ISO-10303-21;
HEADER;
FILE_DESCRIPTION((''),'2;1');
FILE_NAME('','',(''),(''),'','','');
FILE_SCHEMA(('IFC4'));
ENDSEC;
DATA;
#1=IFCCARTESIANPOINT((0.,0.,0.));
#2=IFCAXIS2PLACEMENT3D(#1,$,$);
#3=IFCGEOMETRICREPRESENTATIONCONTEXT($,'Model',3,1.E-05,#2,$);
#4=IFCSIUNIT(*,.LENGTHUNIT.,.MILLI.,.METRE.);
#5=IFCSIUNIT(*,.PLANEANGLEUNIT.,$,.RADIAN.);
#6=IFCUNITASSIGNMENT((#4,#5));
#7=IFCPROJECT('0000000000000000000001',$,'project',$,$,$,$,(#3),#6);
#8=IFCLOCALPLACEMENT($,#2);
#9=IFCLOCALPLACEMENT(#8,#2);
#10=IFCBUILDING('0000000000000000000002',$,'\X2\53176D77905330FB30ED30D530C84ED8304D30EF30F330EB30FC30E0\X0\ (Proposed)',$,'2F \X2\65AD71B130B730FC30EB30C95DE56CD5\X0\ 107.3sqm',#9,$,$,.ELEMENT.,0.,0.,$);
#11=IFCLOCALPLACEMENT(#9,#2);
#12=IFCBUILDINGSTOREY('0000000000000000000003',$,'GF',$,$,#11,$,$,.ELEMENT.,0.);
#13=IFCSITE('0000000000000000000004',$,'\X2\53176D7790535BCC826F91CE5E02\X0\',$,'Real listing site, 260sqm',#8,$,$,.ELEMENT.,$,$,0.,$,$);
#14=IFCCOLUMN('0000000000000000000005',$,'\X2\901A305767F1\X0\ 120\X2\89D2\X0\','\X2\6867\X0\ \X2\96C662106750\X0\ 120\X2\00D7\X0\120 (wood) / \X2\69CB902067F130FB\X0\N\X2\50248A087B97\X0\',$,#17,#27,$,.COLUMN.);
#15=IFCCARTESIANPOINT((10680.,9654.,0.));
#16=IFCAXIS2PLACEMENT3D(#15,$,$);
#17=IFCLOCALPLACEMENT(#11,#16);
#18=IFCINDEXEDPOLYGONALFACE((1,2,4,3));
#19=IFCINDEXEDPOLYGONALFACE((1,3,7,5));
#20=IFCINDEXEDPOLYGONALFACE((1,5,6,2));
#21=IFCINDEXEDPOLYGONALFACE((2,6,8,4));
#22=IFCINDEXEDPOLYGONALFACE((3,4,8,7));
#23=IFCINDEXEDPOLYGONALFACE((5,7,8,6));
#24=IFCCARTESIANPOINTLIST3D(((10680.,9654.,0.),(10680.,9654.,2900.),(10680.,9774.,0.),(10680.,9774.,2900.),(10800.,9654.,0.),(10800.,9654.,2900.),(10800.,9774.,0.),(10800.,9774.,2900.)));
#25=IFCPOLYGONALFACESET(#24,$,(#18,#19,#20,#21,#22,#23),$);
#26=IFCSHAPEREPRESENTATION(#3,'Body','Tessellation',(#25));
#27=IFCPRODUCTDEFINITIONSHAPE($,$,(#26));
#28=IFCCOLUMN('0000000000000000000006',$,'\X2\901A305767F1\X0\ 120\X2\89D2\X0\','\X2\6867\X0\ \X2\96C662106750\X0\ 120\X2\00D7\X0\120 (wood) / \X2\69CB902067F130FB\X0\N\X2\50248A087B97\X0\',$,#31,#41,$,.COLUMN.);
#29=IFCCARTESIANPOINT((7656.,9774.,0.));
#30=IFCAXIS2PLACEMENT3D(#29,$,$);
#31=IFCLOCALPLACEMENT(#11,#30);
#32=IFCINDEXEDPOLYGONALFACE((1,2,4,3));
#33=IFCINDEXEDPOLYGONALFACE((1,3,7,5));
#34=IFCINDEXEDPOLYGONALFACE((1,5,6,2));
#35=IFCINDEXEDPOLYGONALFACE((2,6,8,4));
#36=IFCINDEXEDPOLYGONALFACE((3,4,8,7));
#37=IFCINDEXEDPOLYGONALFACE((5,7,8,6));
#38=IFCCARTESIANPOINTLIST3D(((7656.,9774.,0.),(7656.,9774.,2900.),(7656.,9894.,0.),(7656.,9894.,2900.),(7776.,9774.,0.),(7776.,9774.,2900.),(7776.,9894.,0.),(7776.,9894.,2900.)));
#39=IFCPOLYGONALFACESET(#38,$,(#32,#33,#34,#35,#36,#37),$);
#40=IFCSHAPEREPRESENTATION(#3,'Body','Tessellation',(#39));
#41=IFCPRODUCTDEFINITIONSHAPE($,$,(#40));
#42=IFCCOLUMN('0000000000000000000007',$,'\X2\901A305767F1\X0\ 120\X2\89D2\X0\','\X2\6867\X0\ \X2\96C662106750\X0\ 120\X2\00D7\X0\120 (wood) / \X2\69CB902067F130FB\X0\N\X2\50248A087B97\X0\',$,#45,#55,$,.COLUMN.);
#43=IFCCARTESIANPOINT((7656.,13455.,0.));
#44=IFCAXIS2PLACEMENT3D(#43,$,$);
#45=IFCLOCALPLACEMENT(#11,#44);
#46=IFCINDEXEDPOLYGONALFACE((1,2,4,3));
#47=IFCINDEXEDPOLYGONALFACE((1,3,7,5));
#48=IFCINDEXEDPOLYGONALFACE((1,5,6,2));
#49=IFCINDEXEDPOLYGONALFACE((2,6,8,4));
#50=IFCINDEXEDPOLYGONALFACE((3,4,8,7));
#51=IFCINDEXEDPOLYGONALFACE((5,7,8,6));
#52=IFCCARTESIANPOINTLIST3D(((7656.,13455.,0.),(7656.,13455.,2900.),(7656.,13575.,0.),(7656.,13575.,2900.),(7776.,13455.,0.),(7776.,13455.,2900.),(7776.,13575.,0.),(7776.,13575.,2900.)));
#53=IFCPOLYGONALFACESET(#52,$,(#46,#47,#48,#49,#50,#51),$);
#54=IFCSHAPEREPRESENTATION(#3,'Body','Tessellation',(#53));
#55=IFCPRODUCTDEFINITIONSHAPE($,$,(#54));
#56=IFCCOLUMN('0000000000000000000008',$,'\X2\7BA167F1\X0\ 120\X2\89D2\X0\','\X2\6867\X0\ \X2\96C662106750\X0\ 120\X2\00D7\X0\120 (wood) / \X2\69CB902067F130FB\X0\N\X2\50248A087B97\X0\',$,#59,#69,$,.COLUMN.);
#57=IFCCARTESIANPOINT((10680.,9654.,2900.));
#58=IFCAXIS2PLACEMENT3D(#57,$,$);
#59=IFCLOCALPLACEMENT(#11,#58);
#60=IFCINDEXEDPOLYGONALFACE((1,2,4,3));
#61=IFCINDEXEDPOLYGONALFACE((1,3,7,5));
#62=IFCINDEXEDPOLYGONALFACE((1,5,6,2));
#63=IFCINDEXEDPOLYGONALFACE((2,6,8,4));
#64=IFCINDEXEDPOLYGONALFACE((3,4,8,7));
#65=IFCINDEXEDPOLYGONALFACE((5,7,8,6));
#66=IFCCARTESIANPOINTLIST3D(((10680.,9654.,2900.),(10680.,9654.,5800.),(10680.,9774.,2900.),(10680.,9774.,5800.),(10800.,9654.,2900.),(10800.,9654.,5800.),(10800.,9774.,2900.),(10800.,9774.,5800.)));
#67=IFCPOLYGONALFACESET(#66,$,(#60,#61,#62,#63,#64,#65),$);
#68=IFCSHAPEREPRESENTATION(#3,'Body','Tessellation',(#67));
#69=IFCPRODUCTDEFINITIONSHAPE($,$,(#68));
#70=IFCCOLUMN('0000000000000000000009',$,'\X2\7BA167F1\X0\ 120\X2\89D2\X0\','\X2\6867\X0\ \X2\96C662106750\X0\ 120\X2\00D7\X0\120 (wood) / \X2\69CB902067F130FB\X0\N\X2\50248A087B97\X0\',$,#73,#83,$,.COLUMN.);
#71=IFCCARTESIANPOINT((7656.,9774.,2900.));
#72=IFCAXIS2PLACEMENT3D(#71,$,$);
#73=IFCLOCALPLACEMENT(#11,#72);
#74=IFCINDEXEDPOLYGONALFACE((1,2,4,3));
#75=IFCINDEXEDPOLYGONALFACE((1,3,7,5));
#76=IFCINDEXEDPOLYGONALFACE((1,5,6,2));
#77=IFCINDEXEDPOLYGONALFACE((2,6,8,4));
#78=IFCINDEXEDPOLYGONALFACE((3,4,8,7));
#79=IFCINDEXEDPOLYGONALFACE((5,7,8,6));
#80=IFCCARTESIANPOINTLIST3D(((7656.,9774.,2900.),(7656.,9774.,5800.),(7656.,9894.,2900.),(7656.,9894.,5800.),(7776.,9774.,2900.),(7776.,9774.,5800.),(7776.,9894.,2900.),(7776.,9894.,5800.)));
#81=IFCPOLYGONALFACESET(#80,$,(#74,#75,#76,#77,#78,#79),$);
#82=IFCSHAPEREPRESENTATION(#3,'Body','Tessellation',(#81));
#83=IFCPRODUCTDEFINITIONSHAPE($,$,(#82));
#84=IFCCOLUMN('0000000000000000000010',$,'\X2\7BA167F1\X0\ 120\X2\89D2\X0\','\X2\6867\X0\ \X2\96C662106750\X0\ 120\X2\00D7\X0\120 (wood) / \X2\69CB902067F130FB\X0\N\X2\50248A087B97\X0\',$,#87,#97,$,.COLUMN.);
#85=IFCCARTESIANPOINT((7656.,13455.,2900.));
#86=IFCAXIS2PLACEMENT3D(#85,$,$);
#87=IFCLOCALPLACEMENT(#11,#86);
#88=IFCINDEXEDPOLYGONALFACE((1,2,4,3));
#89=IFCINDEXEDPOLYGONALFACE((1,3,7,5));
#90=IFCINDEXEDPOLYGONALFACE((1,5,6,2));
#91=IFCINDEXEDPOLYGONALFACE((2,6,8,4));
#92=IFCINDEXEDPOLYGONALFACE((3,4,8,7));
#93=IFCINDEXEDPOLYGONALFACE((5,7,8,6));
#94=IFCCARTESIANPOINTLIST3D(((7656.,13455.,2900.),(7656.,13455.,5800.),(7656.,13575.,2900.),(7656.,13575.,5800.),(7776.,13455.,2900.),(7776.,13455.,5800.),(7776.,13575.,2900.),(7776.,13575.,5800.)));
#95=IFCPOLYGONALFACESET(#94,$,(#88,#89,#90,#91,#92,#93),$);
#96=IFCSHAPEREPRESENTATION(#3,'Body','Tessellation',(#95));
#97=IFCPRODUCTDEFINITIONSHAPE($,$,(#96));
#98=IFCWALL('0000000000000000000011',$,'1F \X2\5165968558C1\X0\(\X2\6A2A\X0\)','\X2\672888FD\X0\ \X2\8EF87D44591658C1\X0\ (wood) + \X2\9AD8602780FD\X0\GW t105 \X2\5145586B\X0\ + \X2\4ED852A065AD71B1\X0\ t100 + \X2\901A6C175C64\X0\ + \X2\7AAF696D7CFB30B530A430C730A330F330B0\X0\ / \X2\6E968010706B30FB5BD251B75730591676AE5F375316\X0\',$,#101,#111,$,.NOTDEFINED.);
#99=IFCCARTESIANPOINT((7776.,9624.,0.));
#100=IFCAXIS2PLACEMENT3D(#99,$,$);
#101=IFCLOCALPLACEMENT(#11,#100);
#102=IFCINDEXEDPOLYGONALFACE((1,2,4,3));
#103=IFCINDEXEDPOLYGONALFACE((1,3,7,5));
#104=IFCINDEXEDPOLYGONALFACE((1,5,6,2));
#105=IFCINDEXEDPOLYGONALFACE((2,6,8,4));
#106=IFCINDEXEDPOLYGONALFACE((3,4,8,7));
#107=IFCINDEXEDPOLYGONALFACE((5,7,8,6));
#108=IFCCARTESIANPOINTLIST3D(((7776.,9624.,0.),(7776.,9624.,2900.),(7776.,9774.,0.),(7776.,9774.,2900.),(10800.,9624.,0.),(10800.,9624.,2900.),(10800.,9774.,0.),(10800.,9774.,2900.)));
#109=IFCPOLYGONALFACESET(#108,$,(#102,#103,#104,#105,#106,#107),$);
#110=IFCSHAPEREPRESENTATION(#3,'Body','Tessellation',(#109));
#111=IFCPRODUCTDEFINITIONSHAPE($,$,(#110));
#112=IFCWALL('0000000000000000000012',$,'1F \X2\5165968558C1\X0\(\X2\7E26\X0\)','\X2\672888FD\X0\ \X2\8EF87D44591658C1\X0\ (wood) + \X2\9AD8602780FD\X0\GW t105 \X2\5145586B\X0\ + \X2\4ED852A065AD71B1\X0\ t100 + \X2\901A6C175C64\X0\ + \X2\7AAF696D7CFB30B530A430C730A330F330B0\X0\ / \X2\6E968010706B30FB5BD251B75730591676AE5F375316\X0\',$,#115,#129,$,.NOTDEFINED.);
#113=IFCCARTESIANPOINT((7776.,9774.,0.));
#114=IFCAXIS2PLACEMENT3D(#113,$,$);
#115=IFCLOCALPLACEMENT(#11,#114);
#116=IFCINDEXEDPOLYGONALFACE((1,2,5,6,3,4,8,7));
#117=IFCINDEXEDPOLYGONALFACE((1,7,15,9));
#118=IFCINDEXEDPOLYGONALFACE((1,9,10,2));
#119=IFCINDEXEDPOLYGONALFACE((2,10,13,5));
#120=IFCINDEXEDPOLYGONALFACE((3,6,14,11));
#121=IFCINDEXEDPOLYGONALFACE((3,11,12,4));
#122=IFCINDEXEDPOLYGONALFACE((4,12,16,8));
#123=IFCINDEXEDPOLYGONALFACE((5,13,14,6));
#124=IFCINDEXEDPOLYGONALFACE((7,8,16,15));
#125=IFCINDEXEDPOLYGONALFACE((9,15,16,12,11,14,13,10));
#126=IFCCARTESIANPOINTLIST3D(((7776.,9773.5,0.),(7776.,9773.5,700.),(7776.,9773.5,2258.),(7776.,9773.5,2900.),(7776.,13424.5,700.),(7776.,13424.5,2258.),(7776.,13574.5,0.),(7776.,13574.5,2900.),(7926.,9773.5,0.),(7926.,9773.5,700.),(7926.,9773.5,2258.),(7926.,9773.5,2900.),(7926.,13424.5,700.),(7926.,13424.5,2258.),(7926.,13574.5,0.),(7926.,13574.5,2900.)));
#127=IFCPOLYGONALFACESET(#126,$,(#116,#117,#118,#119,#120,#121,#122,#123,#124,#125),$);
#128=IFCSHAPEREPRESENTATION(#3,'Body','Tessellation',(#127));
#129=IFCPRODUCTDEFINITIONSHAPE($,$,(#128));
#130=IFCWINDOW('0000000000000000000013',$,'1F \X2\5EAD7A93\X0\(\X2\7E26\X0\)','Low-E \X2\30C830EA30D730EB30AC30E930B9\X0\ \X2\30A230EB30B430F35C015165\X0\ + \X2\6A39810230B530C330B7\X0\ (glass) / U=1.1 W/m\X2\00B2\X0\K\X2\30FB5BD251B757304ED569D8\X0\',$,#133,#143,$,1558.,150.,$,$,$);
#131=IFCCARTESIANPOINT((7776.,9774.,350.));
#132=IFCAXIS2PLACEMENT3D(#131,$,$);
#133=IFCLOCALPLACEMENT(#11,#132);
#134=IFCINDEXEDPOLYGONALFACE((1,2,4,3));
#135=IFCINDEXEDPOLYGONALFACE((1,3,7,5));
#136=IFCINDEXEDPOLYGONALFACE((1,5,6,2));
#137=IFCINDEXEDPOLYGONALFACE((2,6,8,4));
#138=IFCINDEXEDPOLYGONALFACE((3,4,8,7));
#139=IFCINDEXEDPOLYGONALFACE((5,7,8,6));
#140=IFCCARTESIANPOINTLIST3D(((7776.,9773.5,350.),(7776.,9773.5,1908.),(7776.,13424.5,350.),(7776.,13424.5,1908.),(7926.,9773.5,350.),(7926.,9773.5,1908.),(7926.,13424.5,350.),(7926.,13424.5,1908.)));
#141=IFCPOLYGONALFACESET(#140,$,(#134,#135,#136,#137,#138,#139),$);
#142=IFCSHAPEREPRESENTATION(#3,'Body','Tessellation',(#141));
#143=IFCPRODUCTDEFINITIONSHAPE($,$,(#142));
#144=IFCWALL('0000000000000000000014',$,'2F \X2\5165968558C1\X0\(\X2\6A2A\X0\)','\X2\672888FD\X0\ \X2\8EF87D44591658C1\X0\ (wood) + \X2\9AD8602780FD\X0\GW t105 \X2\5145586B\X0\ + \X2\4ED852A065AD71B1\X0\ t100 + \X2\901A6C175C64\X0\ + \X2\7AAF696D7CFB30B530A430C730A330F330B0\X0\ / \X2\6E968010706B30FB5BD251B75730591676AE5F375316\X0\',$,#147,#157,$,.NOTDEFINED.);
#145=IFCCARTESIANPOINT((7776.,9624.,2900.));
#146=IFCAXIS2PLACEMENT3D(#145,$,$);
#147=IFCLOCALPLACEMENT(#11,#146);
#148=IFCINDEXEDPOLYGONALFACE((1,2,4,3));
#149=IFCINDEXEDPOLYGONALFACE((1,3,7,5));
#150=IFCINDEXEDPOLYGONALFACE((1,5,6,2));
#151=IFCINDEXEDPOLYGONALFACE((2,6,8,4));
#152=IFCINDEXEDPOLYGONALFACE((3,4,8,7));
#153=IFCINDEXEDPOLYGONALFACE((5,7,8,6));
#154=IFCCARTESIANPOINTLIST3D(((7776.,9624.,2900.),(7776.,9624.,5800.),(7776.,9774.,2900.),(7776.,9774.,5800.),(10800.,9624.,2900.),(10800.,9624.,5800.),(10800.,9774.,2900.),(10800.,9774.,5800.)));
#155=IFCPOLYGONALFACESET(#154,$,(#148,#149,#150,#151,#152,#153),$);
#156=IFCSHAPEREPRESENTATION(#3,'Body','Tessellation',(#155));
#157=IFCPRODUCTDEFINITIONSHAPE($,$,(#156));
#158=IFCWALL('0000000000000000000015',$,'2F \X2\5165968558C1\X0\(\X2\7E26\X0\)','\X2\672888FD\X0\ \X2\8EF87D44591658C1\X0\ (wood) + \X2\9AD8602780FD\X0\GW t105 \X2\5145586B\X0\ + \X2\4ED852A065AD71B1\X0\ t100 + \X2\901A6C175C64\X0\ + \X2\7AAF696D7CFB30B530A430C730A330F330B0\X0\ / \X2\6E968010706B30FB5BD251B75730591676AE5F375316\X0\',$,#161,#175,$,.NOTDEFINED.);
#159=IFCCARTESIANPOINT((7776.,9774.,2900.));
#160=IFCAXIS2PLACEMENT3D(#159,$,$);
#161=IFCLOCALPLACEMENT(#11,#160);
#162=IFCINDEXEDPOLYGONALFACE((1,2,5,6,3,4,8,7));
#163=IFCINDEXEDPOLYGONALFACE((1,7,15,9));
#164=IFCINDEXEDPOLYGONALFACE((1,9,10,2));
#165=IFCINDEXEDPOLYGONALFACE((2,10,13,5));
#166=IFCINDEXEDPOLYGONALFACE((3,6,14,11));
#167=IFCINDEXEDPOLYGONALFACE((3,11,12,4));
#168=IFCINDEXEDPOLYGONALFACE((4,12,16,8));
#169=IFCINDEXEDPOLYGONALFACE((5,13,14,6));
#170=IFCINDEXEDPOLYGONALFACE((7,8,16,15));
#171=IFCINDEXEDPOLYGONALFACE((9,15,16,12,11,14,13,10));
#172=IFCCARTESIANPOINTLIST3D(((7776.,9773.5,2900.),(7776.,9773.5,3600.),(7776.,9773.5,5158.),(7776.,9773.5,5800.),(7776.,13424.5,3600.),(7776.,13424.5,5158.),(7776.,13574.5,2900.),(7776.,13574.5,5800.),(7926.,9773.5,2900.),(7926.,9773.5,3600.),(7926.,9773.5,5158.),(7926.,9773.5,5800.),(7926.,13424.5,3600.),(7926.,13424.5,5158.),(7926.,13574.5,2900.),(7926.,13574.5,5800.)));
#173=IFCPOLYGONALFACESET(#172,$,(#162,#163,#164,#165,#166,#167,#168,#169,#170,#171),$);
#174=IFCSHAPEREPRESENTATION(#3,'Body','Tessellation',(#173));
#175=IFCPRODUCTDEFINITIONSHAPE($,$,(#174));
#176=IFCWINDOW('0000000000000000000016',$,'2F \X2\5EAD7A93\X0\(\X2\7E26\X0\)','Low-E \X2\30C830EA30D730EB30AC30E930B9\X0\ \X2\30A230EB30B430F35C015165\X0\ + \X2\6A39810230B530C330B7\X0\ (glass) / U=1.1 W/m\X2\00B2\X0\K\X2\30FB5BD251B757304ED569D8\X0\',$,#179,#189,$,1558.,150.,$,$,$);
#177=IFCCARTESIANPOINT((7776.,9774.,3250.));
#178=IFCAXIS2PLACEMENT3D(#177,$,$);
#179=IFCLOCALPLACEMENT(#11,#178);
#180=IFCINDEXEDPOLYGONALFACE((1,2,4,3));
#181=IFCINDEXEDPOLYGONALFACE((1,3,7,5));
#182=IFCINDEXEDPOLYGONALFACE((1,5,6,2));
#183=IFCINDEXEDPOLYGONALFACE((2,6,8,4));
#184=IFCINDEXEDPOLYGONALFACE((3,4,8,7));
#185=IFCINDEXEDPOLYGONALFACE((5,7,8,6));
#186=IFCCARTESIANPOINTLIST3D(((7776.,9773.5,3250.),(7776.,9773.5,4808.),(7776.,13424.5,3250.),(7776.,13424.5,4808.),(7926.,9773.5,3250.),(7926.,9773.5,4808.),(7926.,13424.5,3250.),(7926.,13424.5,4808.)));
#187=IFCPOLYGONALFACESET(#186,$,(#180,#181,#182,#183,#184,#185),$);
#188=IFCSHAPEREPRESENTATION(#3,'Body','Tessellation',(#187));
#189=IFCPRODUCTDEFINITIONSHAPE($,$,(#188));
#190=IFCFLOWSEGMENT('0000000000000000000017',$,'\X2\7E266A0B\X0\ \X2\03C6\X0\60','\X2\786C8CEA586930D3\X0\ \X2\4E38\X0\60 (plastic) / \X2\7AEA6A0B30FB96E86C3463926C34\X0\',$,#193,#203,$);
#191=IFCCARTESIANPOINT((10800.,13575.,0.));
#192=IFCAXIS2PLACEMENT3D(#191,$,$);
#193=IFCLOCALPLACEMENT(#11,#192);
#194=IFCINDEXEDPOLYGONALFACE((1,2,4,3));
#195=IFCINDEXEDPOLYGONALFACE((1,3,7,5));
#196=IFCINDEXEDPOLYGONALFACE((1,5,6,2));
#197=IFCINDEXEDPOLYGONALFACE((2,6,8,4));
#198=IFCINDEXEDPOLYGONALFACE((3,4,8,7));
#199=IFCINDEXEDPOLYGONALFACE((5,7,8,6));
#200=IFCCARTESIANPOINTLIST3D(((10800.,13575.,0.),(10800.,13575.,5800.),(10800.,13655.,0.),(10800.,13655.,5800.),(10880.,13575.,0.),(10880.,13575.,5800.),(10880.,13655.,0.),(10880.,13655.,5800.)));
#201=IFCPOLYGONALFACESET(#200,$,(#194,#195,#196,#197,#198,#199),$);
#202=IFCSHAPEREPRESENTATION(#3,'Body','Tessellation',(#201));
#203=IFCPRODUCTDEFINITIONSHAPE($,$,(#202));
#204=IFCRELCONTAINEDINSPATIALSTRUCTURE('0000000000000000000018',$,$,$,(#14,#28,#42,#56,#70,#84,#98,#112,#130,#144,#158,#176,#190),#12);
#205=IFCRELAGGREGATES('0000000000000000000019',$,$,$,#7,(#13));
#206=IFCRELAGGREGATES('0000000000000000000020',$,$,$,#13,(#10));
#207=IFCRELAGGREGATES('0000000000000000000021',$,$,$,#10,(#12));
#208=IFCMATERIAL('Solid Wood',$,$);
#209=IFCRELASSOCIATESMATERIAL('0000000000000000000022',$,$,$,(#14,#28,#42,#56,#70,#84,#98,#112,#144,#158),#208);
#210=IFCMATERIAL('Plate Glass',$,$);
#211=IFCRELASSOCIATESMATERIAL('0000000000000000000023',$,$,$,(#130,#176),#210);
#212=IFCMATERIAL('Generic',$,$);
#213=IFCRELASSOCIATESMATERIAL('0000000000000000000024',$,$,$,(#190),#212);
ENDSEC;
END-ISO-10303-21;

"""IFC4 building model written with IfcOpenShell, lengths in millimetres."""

from ifc_helpers import new_model, si_unit, frame, frame_2d, origin, place, context, project, spatial, rectangle, extrude, material, element, fill, save


model = new_model("IFC4")

# Units and contexts
model_context = context("Model", 3, precision=1e-05, world=origin())
ifc_project = project(units=[si_unit("LENGTHUNIT", "METRE", prefix="MILLI"), si_unit("PLANEANGLEUNIT", "RADIAN")], contexts=[model_context])

# Site, building, storey
site_placement = place(None, origin())
site = spatial("IfcSite", under=ifc_project, at=site_placement, Name="北海道富良野市", ObjectType="Real listing site, 260sqm", CompositionType="ELEMENT", RefElevation=0.0)
building_placement = place(site_placement, origin())
building = spatial("IfcBuilding", under=site, at=building_placement, Name="北海道・ロフト付きワンルーム (Proposed)", ObjectType="2F 断熱シールド工法 107.3sqm", CompositionType="ELEMENT", ElevationOfRefHeight=0.0, ElevationOfTerrain=0.0)
storey_placement = place(building_placement, origin())
storey = spatial("IfcBuildingStorey", under=building, at=storey_placement, Name="GF", CompositionType="ELEMENT", Elevation=0.0)

# Columns
ifc_material_1 = material(Name="Solid Wood")
column_1_placement = place(storey_placement, frame((10680.0, 9654.0, 0.0)))
element("IfcColumn", 1, at=column_1_placement, inside=storey, material=ifc_material_1, Name="通し柱 120角", Description="桧 集成材 120×120 (wood) / 構造柱・N値計算", PredefinedType="COLUMN", context=model_context, shape_type="SweptSolid", body=[
    extrude(rectangle(XDim=120.0, YDim=120.0, at=frame_2d((60.0, 60.0))), frame((10680.0, 9654.0, 0.0)), (0.0, 0.0, 1.0), 2900.0),
])
column_2_placement = place(storey_placement, frame((7656.0, 9774.0, 0.0)))
element("IfcColumn", 2, at=column_2_placement, inside=storey, material=ifc_material_1, Name="通し柱 120角", Description="桧 集成材 120×120 (wood) / 構造柱・N値計算", PredefinedType="COLUMN", context=model_context, shape_type="SweptSolid", body=[
    extrude(rectangle(XDim=120.0, YDim=120.0, at=frame_2d((60.0, 60.0))), frame((7656.0, 9774.0, 0.0)), (0.0, 0.0, 1.0), 2900.0),
])
column_3_placement = place(storey_placement, frame((7656.0, 13455.0, 0.0)))
element("IfcColumn", 3, at=column_3_placement, inside=storey, material=ifc_material_1, Name="通し柱 120角", Description="桧 集成材 120×120 (wood) / 構造柱・N値計算", PredefinedType="COLUMN", context=model_context, shape_type="SweptSolid", body=[
    extrude(rectangle(XDim=120.0, YDim=120.0, at=frame_2d((60.0, 60.0))), frame((7656.0, 13455.0, 0.0)), (0.0, 0.0, 1.0), 2900.0),
])
column_4_placement = place(storey_placement, frame((10680.0, 9654.0, 2900.0)))
element("IfcColumn", 4, at=column_4_placement, inside=storey, material=ifc_material_1, Name="管柱 120角", Description="桧 集成材 120×120 (wood) / 構造柱・N値計算", PredefinedType="COLUMN", context=model_context, shape_type="SweptSolid", body=[
    extrude(rectangle(XDim=120.0, YDim=120.0, at=frame_2d((60.0, 60.0))), frame((10680.0, 9654.0, 2900.0)), (0.0, 0.0, 1.0), 2900.0),
])
column_5_placement = place(storey_placement, frame((7656.0, 9774.0, 2900.0)))
element("IfcColumn", 5, at=column_5_placement, inside=storey, material=ifc_material_1, Name="管柱 120角", Description="桧 集成材 120×120 (wood) / 構造柱・N値計算", PredefinedType="COLUMN", context=model_context, shape_type="SweptSolid", body=[
    extrude(rectangle(XDim=120.0, YDim=120.0, at=frame_2d((60.0, 60.0))), frame((7656.0, 9774.0, 2900.0)), (0.0, 0.0, 1.0), 2900.0),
])
column_6_placement = place(storey_placement, frame((7656.0, 13455.0, 2900.0)))
element("IfcColumn", 6, at=column_6_placement, inside=storey, material=ifc_material_1, Name="管柱 120角", Description="桧 集成材 120×120 (wood) / 構造柱・N値計算", PredefinedType="COLUMN", context=model_context, shape_type="SweptSolid", body=[
    extrude(rectangle(XDim=120.0, YDim=120.0, at=frame_2d((60.0, 60.0))), frame((7656.0, 13455.0, 2900.0)), (0.0, 0.0, 1.0), 2900.0),
])

# Wall
wall_1_placement = place(storey_placement, frame((7776.0, 9624.0, 0.0)))
element("IfcWall", 7, at=wall_1_placement, inside=storey, material=ifc_material_1, Name="1F 入隅壁(横)", Description="木製 軸組外壁 (wood) + 高性能GW t105 充填 + 付加断熱 t100 + 通気層 + 窯業系サイディング / 準耐火・寒冷地外皮強化", PredefinedType="NOTDEFINED", context=model_context, shape_type="SweptSolid", body=[
    extrude(rectangle(XDim=3024.0, YDim=150.0, at=frame_2d((1512.0, 75.0))), frame((7776.0, 9624.0, 0.0)), (0.0, 0.0, 1.0), 2900.0),
])

# Wall, opening, window
wall_2_placement = place(storey_placement, frame((7776.0, 9774.0, 0.0)))
wall_2 = element("IfcWall", 8, at=wall_2_placement, inside=storey, material=ifc_material_1, Name="1F 入隅壁(縦)", Description="木製 軸組外壁 (wood) + 高性能GW t105 充填 + 付加断熱 t100 + 通気層 + 窯業系サイディング / 準耐火・寒冷地外皮強化", PredefinedType="NOTDEFINED", context=model_context, shape_type="SweptSolid", body=[
    extrude(rectangle(XDim=150.0, YDim=3801.0, at=frame_2d((75.0, 1900.0))), frame((7776.0, 9774.0, 0.0)), (0.0, 0.0, 1.0), 2900.0),
])
opening_1_placement = place(storey_placement, frame((7776.0, 9774.0, 350.0)))
opening_1 = element("IfcOpeningElement", 9, at=opening_1_placement, cuts=wall_2, PredefinedType="NOTDEFINED", context=model_context, shape_type="SweptSolid", body=[
    extrude(rectangle(XDim=150.0, YDim=3651.0, at=frame_2d((75.0, 1825.0))), frame((7776.0, 9774.0, 350.0)), (0.0, 0.0, 1.0), 1558.0),
])
ifc_material_2 = material(Name="Plate Glass")
window_1_placement = place(storey_placement, frame((7776.0, 9774.0, 350.0)))
window_1 = element("IfcWindow", 10, at=window_1_placement, inside=storey, material=ifc_material_2, Name="1F 庭窓(縦)", Description="Low-E トリプルガラス アルゴン封入 + 樹脂サッシ (glass) / U=1.1 W/m²K・寒冷地仕様", OverallHeight=1558.0, OverallWidth=150.0, context=model_context, shape_type="SweptSolid", body=[
    extrude(rectangle(XDim=150.0, YDim=3651.0, at=frame_2d((75.0, 1825.0))), frame((7776.0, 9774.0, 350.0)), (0.0, 0.0, 1.0), 1558.0),
])
fill(opening_1, window_1)

# Wall
wall_3_placement = place(storey_placement, frame((7776.0, 9624.0, 2900.0)))
element("IfcWall", 11, at=wall_3_placement, inside=storey, material=ifc_material_1, Name="2F 入隅壁(横)", Description="木製 軸組外壁 (wood) + 高性能GW t105 充填 + 付加断熱 t100 + 通気層 + 窯業系サイディング / 準耐火・寒冷地外皮強化", PredefinedType="NOTDEFINED", context=model_context, shape_type="SweptSolid", body=[
    extrude(rectangle(XDim=3024.0, YDim=150.0, at=frame_2d((1512.0, 75.0))), frame((7776.0, 9624.0, 2900.0)), (0.0, 0.0, 1.0), 2900.0),
])

# Wall, opening, window
wall_4_placement = place(storey_placement, frame((7776.0, 9774.0, 2900.0)))
wall_4 = element("IfcWall", 12, at=wall_4_placement, inside=storey, material=ifc_material_1, Name="2F 入隅壁(縦)", Description="木製 軸組外壁 (wood) + 高性能GW t105 充填 + 付加断熱 t100 + 通気層 + 窯業系サイディング / 準耐火・寒冷地外皮強化", PredefinedType="NOTDEFINED", context=model_context, shape_type="SweptSolid", body=[
    extrude(rectangle(XDim=150.0, YDim=3801.0, at=frame_2d((75.0, 1900.0))), frame((7776.0, 9774.0, 2900.0)), (0.0, 0.0, 1.0), 2900.0),
])
opening_2_placement = place(storey_placement, frame((7776.0, 9774.0, 3250.0)))
opening_2 = element("IfcOpeningElement", 13, at=opening_2_placement, cuts=wall_4, PredefinedType="NOTDEFINED", context=model_context, shape_type="SweptSolid", body=[
    extrude(rectangle(XDim=150.0, YDim=3651.0, at=frame_2d((75.0, 1825.0))), frame((7776.0, 9774.0, 3250.0)), (0.0, 0.0, 1.0), 1558.0),
])
window_2_placement = place(storey_placement, frame((7776.0, 9774.0, 3250.0)))
window_2 = element("IfcWindow", 14, at=window_2_placement, inside=storey, material=ifc_material_2, Name="2F 庭窓(縦)", Description="Low-E トリプルガラス アルゴン封入 + 樹脂サッシ (glass) / U=1.1 W/m²K・寒冷地仕様", OverallHeight=1558.0, OverallWidth=150.0, context=model_context, shape_type="SweptSolid", body=[
    extrude(rectangle(XDim=150.0, YDim=3651.0, at=frame_2d((75.0, 1825.0))), frame((7776.0, 9774.0, 3250.0)), (0.0, 0.0, 1.0), 1558.0),
])
fill(opening_2, window_2)

# Flow segment
ifc_material_3 = material(Name="Generic")
flow_segment_placement = place(storey_placement, frame((10800.0, 13575.0, 0.0)))
element("IfcFlowSegment", 15, at=flow_segment_placement, inside=storey, material=ifc_material_3, Name="縦樋 φ60", Description="硬質塩ビ 丸60 (plastic) / 竪樋・雨水排水", context=model_context, shape_type="SweptSolid", body=[
    extrude(rectangle(XDim=80.0, YDim=80.0, at=frame_2d((40.0, 40.0))), frame((10800.0, 13575.0, 0.0)), (0.0, 0.0, 1.0), 5800.0),
])

save(model, "model.ifc")
